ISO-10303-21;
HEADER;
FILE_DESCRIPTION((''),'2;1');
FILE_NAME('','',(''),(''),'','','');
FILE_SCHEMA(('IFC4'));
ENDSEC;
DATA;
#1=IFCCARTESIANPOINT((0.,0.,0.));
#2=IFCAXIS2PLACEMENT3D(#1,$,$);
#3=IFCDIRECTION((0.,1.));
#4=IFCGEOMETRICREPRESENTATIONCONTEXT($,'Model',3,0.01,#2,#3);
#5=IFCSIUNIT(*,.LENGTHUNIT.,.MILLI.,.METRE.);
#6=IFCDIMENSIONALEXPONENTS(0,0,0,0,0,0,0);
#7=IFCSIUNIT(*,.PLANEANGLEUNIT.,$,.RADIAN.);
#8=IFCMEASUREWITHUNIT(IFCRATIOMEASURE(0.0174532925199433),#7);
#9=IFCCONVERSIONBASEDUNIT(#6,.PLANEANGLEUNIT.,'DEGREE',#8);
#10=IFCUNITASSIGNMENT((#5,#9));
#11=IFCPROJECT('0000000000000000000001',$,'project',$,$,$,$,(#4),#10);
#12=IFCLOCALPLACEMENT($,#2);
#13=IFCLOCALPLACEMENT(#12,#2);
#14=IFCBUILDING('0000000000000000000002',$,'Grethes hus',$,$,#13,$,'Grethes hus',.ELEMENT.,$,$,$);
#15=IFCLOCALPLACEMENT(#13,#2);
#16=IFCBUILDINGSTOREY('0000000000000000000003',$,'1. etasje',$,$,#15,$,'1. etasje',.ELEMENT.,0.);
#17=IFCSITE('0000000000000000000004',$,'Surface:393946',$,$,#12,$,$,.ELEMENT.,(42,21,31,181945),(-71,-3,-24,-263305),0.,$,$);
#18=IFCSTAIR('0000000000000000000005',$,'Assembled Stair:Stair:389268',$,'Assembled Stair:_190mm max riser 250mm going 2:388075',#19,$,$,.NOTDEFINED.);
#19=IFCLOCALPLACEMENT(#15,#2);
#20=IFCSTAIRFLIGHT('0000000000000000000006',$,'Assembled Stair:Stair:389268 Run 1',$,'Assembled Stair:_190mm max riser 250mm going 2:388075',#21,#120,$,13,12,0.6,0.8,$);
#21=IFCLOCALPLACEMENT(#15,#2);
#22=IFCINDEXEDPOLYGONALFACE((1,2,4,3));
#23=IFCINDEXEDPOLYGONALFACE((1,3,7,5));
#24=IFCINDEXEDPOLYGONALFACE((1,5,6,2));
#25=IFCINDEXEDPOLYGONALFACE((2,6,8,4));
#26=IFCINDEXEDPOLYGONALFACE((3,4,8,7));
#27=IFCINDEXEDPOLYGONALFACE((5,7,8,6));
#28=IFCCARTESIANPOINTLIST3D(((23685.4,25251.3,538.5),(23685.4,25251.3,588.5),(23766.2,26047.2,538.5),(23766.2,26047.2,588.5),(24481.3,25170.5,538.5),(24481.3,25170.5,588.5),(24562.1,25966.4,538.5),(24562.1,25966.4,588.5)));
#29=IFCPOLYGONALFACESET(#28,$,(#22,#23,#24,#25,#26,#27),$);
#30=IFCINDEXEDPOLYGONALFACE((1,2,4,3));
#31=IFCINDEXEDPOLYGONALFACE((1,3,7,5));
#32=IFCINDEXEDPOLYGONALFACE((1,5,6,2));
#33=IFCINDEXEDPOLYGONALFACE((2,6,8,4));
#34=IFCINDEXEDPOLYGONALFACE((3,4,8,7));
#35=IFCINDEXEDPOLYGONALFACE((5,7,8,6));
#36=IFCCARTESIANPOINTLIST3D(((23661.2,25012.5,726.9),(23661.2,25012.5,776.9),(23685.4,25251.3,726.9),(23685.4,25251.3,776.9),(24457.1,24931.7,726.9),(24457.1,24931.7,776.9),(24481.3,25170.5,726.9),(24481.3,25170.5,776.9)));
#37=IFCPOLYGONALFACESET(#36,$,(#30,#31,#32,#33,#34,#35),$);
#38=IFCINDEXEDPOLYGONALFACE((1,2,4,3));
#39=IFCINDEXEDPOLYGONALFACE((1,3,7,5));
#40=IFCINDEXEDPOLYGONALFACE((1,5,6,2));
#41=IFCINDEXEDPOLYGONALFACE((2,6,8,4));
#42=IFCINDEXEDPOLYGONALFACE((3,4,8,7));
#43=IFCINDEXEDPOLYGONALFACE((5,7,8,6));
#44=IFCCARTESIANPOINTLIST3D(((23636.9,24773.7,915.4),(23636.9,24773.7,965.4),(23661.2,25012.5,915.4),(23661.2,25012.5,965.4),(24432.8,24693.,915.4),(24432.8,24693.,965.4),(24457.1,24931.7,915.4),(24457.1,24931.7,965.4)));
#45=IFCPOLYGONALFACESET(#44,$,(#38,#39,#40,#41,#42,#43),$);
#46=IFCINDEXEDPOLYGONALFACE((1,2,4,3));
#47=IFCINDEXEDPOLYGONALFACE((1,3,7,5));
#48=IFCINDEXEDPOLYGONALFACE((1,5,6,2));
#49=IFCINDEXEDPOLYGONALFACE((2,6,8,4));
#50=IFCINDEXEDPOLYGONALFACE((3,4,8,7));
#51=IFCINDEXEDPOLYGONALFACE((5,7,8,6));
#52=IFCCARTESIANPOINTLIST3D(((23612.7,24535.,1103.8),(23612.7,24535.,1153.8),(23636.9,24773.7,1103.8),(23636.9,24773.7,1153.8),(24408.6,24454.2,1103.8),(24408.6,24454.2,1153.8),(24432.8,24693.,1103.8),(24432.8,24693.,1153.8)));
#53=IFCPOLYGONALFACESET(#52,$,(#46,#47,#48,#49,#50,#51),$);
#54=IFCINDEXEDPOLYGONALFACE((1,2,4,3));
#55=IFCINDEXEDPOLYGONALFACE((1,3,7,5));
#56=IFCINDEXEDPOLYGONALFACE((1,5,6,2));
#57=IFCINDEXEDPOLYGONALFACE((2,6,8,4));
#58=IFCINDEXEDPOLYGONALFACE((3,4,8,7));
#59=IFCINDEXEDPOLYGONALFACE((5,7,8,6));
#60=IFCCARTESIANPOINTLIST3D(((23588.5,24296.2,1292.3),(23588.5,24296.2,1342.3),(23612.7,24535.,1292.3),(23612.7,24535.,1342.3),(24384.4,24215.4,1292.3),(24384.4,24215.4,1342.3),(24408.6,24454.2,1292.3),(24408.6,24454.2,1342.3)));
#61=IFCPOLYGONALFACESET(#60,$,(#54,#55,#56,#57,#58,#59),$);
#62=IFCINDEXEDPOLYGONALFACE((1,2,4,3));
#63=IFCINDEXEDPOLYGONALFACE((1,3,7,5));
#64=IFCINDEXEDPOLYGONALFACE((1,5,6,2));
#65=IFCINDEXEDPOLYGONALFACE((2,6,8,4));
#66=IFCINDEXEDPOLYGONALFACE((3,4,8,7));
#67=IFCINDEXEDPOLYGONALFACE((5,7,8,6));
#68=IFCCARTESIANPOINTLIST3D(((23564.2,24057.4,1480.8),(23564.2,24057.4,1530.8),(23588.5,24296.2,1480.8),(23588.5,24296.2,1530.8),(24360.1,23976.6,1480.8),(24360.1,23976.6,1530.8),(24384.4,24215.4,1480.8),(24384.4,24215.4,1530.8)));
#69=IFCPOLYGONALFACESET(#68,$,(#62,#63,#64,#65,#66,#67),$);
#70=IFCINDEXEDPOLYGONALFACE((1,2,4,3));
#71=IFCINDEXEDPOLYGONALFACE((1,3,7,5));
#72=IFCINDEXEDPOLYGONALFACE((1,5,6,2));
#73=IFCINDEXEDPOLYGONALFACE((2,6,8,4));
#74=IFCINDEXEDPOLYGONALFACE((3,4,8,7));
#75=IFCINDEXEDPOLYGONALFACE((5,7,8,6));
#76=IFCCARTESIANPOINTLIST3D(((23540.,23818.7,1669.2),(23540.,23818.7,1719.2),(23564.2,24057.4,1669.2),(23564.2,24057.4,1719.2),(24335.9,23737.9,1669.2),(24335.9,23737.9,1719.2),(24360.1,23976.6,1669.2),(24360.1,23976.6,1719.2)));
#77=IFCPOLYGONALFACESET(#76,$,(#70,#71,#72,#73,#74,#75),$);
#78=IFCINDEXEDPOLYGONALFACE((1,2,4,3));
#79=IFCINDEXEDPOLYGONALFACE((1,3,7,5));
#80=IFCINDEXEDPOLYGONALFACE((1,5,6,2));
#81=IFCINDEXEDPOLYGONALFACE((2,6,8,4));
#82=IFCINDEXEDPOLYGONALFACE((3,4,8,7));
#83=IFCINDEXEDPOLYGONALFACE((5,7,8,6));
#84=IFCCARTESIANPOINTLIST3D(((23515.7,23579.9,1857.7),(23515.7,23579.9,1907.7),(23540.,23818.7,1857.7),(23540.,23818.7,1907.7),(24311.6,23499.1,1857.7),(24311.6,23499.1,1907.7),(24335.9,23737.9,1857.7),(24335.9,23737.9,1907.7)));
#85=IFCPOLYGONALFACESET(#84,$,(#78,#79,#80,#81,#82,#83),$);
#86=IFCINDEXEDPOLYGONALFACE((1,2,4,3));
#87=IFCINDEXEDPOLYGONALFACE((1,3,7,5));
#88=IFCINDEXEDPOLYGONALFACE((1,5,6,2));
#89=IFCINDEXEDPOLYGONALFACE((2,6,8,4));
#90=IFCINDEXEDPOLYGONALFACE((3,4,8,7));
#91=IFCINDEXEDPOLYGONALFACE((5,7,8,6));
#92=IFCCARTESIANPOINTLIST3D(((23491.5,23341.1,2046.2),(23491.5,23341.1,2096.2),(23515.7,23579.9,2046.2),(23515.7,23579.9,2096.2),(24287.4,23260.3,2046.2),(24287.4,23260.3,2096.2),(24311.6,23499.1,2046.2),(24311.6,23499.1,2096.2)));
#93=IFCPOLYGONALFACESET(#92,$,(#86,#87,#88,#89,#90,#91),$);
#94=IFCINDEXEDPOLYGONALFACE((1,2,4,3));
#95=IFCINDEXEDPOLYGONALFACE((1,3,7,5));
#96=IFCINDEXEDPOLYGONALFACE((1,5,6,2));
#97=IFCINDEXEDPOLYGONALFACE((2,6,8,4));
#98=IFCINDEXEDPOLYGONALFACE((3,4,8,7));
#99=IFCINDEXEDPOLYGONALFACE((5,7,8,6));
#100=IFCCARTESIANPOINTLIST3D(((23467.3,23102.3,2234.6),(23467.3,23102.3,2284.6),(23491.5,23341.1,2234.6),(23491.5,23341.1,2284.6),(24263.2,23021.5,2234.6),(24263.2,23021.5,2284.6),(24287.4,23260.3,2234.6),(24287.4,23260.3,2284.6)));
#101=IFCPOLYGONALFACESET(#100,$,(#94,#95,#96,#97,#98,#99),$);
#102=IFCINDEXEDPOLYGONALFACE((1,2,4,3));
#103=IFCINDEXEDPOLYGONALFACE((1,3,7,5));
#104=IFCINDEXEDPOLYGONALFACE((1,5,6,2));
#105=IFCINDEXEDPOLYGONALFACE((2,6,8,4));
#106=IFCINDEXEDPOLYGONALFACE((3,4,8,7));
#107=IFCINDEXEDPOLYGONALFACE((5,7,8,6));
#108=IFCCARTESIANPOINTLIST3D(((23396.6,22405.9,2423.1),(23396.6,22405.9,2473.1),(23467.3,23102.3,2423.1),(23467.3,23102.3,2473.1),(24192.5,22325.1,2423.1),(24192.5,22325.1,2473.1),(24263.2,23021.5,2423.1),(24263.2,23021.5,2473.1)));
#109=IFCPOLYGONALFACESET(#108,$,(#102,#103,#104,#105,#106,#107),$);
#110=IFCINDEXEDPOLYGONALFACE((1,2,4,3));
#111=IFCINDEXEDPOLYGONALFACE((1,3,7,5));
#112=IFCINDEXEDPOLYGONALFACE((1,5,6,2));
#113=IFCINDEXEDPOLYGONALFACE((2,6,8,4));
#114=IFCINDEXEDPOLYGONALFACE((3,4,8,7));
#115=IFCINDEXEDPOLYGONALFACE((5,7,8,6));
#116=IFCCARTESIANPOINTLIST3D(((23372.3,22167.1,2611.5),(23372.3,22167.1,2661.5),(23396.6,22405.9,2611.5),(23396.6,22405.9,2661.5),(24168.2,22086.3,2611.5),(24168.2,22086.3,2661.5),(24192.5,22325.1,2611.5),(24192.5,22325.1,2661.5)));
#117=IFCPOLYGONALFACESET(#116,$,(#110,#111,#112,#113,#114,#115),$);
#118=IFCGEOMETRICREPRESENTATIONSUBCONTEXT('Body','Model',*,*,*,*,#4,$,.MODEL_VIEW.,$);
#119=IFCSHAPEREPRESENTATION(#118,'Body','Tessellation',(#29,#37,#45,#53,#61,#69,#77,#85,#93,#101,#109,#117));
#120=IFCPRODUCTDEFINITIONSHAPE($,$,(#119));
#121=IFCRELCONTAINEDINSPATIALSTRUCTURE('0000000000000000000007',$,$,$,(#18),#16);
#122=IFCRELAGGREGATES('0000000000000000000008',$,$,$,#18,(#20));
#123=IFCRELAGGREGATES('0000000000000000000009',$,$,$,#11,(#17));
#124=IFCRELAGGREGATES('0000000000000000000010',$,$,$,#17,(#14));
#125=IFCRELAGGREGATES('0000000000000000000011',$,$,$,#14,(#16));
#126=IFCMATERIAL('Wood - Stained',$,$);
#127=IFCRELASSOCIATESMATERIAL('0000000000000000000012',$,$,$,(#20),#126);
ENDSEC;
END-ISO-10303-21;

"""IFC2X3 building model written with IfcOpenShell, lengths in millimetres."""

from ifc_helpers import new_model, entity, si_unit, converted_unit, direction, frame, frame_2d, origin, origin_2d_with_axis, place, context, subcontext, project, spatial, rectangle, extrude, material, element, aggregate, save


model = new_model("IFC2X3")

# Units and contexts
model_context = context("Model", 3, precision=0.01, world=origin(), true_north=direction((0.0, 1.0)))
body_context = subcontext(model_context, "Body", "Model", "MODEL_VIEW")
ifc_project = project(units=[si_unit("LENGTHUNIT", "METRE", prefix="MILLI"), converted_unit("PLANEANGLEUNIT", "DEGREE", entity("IfcRatioMeasure", 0.0174532925199433), si_unit("PLANEANGLEUNIT", "RADIAN"), dimensions=[0, 0, 0, 0, 0, 0, 0])], contexts=[model_context])

# Site, building, storey
site_placement = place(None, origin())
site = spatial("IfcSite", under=ifc_project, at=site_placement, Name="Surface:393946", CompositionType="ELEMENT", RefLatitude=(42, 21, 31, 181945), RefLongitude=(-71, -3, -24, -263305), RefElevation=0.0)
building_placement = place(site_placement, origin())
building = spatial("IfcBuilding", under=site, at=building_placement, Name="Grethes hus", LongName="Grethes hus", CompositionType="ELEMENT")
storey_placement = place(building_placement, origin())
storey = spatial("IfcBuildingStorey", under=building, at=storey_placement, Name="1. etasje", LongName="1. etasje", CompositionType="ELEMENT", Elevation=0.0)

# Stair, stair flight
ifc_material_1 = material(Name="Wood - Stained")
stair_1_placement = place(storey_placement, origin())
stair_1 = element("IfcStair", 1, at=stair_1_placement, inside=storey, Name="Assembled Stair:Stair:389268", ObjectType="Assembled Stair:_190mm max riser 250mm going 2:388075", ShapeType="NOTDEFINED")
stair_flight_1_placement = place(stair_1_placement, origin())
stair_flight_1 = element("IfcStairFlight", 2, at=stair_flight_1_placement, material=ifc_material_1, Name="Assembled Stair:Stair:389268 Run 1", ObjectType="Assembled Stair:_190mm max riser 250mm going 2:388075", NumberOfRiser=13, NumberOfTreads=12, RiserHeight=0.6, TreadLength=0.8, context=body_context, shape_type="SweptSolid", body=[
    extrude(rectangle(XDim=800.0, YDim=800.0, at=frame_2d((0.0, 0.0), x_axis=(1.0, 0.0))), frame((24123.8, 25608.8, 538.5), z_axis=(0.0, 0.0, 1.0), x_axis=(0.100996, 0.994887, 0.0)), (0.0, 0.0, 1.0), 50.0),
    extrude(rectangle(XDim=240.0, YDim=800.0, at=origin_2d_with_axis()), frame((24071.2, 25091.5, 726.9), z_axis=(0.0, 0.0, 1.0), x_axis=(0.100996, 0.994887, 0.0)), (0.0, 0.0, 1.0), 50.0),
    extrude(rectangle(XDim=240.0, YDim=800.0, at=origin_2d_with_axis()), frame((24047.0, 24852.7, 915.4), z_axis=(0.0, 0.0, 1.0), x_axis=(0.100996, 0.994887, 0.0)), (0.0, 0.0, 1.0), 50.0),
    extrude(rectangle(XDim=240.0, YDim=800.0, at=origin_2d_with_axis()), frame((24022.8, 24614.0, 1103.8), z_axis=(0.0, 0.0, 1.0), x_axis=(0.100996, 0.994887, 0.0)), (0.0, 0.0, 1.0), 50.0),
    extrude(rectangle(XDim=240.0, YDim=800.0, at=origin_2d_with_axis()), frame((23998.5, 24375.2, 1292.3), z_axis=(0.0, 0.0, 1.0), x_axis=(0.100996, 0.994887, 0.0)), (0.0, 0.0, 1.0), 50.0),
    extrude(rectangle(XDim=240.0, YDim=800.0, at=origin_2d_with_axis()), frame((23974.3, 24136.4, 1480.8), z_axis=(0.0, 0.0, 1.0), x_axis=(0.100996, 0.994887, 0.0)), (0.0, 0.0, 1.0), 50.0),
    extrude(rectangle(XDim=240.0, YDim=800.0, at=frame_2d((0.0, 0.0), x_axis=(1.0, 0.0))), frame((23950.1, 23897.6, 1669.2), z_axis=(0.0, 0.0, 1.0), x_axis=(0.100996, 0.994887, 0.0)), (0.0, 0.0, 1.0), 50.0),
    extrude(rectangle(XDim=240.0, YDim=800.0, at=origin_2d_with_axis()), frame((23925.8, 23658.9, 1857.7), z_axis=(0.0, 0.0, 1.0), x_axis=(0.100996, 0.994887, 0.0)), (0.0, 0.0, 1.0), 50.0),
    extrude(rectangle(XDim=240.0, YDim=800.0, at=origin_2d_with_axis()), frame((23901.6, 23420.1, 2046.2), z_axis=(0.0, 0.0, 1.0), x_axis=(0.100996, 0.994887, 0.0)), (0.0, 0.0, 1.0), 50.0),
    extrude(rectangle(XDim=240.0, YDim=800.0, at=origin_2d_with_axis()), frame((23877.3, 23181.3, 2234.6), z_axis=(0.0, 0.0, 1.0), x_axis=(0.100996, 0.994887, 0.0)), (0.0, 0.0, 1.0), 50.0),
    extrude(rectangle(XDim=700.0, YDim=800.0, at=frame_2d((0.0, 0.0), x_axis=(1.0, 0.0))), frame((23829.9, 22713.7, 2423.1), z_axis=(0.0, 0.0, 1.0), x_axis=(0.100996, 0.994887, 0.0)), (0.0, 0.0, 1.0), 50.0),
    extrude(rectangle(XDim=240.0, YDim=800.0, at=frame_2d((0.0, 0.0), x_axis=(1.0, 0.0))), frame((23782.4, 22246.1, 2611.5), z_axis=(0.0, 0.0, 1.0), x_axis=(0.100996, 0.994887, 0.0)), (0.0, 0.0, 1.0), 50.0),
])
aggregate(stair_1, [stair_flight_1])

save(model, "model.ifc")
